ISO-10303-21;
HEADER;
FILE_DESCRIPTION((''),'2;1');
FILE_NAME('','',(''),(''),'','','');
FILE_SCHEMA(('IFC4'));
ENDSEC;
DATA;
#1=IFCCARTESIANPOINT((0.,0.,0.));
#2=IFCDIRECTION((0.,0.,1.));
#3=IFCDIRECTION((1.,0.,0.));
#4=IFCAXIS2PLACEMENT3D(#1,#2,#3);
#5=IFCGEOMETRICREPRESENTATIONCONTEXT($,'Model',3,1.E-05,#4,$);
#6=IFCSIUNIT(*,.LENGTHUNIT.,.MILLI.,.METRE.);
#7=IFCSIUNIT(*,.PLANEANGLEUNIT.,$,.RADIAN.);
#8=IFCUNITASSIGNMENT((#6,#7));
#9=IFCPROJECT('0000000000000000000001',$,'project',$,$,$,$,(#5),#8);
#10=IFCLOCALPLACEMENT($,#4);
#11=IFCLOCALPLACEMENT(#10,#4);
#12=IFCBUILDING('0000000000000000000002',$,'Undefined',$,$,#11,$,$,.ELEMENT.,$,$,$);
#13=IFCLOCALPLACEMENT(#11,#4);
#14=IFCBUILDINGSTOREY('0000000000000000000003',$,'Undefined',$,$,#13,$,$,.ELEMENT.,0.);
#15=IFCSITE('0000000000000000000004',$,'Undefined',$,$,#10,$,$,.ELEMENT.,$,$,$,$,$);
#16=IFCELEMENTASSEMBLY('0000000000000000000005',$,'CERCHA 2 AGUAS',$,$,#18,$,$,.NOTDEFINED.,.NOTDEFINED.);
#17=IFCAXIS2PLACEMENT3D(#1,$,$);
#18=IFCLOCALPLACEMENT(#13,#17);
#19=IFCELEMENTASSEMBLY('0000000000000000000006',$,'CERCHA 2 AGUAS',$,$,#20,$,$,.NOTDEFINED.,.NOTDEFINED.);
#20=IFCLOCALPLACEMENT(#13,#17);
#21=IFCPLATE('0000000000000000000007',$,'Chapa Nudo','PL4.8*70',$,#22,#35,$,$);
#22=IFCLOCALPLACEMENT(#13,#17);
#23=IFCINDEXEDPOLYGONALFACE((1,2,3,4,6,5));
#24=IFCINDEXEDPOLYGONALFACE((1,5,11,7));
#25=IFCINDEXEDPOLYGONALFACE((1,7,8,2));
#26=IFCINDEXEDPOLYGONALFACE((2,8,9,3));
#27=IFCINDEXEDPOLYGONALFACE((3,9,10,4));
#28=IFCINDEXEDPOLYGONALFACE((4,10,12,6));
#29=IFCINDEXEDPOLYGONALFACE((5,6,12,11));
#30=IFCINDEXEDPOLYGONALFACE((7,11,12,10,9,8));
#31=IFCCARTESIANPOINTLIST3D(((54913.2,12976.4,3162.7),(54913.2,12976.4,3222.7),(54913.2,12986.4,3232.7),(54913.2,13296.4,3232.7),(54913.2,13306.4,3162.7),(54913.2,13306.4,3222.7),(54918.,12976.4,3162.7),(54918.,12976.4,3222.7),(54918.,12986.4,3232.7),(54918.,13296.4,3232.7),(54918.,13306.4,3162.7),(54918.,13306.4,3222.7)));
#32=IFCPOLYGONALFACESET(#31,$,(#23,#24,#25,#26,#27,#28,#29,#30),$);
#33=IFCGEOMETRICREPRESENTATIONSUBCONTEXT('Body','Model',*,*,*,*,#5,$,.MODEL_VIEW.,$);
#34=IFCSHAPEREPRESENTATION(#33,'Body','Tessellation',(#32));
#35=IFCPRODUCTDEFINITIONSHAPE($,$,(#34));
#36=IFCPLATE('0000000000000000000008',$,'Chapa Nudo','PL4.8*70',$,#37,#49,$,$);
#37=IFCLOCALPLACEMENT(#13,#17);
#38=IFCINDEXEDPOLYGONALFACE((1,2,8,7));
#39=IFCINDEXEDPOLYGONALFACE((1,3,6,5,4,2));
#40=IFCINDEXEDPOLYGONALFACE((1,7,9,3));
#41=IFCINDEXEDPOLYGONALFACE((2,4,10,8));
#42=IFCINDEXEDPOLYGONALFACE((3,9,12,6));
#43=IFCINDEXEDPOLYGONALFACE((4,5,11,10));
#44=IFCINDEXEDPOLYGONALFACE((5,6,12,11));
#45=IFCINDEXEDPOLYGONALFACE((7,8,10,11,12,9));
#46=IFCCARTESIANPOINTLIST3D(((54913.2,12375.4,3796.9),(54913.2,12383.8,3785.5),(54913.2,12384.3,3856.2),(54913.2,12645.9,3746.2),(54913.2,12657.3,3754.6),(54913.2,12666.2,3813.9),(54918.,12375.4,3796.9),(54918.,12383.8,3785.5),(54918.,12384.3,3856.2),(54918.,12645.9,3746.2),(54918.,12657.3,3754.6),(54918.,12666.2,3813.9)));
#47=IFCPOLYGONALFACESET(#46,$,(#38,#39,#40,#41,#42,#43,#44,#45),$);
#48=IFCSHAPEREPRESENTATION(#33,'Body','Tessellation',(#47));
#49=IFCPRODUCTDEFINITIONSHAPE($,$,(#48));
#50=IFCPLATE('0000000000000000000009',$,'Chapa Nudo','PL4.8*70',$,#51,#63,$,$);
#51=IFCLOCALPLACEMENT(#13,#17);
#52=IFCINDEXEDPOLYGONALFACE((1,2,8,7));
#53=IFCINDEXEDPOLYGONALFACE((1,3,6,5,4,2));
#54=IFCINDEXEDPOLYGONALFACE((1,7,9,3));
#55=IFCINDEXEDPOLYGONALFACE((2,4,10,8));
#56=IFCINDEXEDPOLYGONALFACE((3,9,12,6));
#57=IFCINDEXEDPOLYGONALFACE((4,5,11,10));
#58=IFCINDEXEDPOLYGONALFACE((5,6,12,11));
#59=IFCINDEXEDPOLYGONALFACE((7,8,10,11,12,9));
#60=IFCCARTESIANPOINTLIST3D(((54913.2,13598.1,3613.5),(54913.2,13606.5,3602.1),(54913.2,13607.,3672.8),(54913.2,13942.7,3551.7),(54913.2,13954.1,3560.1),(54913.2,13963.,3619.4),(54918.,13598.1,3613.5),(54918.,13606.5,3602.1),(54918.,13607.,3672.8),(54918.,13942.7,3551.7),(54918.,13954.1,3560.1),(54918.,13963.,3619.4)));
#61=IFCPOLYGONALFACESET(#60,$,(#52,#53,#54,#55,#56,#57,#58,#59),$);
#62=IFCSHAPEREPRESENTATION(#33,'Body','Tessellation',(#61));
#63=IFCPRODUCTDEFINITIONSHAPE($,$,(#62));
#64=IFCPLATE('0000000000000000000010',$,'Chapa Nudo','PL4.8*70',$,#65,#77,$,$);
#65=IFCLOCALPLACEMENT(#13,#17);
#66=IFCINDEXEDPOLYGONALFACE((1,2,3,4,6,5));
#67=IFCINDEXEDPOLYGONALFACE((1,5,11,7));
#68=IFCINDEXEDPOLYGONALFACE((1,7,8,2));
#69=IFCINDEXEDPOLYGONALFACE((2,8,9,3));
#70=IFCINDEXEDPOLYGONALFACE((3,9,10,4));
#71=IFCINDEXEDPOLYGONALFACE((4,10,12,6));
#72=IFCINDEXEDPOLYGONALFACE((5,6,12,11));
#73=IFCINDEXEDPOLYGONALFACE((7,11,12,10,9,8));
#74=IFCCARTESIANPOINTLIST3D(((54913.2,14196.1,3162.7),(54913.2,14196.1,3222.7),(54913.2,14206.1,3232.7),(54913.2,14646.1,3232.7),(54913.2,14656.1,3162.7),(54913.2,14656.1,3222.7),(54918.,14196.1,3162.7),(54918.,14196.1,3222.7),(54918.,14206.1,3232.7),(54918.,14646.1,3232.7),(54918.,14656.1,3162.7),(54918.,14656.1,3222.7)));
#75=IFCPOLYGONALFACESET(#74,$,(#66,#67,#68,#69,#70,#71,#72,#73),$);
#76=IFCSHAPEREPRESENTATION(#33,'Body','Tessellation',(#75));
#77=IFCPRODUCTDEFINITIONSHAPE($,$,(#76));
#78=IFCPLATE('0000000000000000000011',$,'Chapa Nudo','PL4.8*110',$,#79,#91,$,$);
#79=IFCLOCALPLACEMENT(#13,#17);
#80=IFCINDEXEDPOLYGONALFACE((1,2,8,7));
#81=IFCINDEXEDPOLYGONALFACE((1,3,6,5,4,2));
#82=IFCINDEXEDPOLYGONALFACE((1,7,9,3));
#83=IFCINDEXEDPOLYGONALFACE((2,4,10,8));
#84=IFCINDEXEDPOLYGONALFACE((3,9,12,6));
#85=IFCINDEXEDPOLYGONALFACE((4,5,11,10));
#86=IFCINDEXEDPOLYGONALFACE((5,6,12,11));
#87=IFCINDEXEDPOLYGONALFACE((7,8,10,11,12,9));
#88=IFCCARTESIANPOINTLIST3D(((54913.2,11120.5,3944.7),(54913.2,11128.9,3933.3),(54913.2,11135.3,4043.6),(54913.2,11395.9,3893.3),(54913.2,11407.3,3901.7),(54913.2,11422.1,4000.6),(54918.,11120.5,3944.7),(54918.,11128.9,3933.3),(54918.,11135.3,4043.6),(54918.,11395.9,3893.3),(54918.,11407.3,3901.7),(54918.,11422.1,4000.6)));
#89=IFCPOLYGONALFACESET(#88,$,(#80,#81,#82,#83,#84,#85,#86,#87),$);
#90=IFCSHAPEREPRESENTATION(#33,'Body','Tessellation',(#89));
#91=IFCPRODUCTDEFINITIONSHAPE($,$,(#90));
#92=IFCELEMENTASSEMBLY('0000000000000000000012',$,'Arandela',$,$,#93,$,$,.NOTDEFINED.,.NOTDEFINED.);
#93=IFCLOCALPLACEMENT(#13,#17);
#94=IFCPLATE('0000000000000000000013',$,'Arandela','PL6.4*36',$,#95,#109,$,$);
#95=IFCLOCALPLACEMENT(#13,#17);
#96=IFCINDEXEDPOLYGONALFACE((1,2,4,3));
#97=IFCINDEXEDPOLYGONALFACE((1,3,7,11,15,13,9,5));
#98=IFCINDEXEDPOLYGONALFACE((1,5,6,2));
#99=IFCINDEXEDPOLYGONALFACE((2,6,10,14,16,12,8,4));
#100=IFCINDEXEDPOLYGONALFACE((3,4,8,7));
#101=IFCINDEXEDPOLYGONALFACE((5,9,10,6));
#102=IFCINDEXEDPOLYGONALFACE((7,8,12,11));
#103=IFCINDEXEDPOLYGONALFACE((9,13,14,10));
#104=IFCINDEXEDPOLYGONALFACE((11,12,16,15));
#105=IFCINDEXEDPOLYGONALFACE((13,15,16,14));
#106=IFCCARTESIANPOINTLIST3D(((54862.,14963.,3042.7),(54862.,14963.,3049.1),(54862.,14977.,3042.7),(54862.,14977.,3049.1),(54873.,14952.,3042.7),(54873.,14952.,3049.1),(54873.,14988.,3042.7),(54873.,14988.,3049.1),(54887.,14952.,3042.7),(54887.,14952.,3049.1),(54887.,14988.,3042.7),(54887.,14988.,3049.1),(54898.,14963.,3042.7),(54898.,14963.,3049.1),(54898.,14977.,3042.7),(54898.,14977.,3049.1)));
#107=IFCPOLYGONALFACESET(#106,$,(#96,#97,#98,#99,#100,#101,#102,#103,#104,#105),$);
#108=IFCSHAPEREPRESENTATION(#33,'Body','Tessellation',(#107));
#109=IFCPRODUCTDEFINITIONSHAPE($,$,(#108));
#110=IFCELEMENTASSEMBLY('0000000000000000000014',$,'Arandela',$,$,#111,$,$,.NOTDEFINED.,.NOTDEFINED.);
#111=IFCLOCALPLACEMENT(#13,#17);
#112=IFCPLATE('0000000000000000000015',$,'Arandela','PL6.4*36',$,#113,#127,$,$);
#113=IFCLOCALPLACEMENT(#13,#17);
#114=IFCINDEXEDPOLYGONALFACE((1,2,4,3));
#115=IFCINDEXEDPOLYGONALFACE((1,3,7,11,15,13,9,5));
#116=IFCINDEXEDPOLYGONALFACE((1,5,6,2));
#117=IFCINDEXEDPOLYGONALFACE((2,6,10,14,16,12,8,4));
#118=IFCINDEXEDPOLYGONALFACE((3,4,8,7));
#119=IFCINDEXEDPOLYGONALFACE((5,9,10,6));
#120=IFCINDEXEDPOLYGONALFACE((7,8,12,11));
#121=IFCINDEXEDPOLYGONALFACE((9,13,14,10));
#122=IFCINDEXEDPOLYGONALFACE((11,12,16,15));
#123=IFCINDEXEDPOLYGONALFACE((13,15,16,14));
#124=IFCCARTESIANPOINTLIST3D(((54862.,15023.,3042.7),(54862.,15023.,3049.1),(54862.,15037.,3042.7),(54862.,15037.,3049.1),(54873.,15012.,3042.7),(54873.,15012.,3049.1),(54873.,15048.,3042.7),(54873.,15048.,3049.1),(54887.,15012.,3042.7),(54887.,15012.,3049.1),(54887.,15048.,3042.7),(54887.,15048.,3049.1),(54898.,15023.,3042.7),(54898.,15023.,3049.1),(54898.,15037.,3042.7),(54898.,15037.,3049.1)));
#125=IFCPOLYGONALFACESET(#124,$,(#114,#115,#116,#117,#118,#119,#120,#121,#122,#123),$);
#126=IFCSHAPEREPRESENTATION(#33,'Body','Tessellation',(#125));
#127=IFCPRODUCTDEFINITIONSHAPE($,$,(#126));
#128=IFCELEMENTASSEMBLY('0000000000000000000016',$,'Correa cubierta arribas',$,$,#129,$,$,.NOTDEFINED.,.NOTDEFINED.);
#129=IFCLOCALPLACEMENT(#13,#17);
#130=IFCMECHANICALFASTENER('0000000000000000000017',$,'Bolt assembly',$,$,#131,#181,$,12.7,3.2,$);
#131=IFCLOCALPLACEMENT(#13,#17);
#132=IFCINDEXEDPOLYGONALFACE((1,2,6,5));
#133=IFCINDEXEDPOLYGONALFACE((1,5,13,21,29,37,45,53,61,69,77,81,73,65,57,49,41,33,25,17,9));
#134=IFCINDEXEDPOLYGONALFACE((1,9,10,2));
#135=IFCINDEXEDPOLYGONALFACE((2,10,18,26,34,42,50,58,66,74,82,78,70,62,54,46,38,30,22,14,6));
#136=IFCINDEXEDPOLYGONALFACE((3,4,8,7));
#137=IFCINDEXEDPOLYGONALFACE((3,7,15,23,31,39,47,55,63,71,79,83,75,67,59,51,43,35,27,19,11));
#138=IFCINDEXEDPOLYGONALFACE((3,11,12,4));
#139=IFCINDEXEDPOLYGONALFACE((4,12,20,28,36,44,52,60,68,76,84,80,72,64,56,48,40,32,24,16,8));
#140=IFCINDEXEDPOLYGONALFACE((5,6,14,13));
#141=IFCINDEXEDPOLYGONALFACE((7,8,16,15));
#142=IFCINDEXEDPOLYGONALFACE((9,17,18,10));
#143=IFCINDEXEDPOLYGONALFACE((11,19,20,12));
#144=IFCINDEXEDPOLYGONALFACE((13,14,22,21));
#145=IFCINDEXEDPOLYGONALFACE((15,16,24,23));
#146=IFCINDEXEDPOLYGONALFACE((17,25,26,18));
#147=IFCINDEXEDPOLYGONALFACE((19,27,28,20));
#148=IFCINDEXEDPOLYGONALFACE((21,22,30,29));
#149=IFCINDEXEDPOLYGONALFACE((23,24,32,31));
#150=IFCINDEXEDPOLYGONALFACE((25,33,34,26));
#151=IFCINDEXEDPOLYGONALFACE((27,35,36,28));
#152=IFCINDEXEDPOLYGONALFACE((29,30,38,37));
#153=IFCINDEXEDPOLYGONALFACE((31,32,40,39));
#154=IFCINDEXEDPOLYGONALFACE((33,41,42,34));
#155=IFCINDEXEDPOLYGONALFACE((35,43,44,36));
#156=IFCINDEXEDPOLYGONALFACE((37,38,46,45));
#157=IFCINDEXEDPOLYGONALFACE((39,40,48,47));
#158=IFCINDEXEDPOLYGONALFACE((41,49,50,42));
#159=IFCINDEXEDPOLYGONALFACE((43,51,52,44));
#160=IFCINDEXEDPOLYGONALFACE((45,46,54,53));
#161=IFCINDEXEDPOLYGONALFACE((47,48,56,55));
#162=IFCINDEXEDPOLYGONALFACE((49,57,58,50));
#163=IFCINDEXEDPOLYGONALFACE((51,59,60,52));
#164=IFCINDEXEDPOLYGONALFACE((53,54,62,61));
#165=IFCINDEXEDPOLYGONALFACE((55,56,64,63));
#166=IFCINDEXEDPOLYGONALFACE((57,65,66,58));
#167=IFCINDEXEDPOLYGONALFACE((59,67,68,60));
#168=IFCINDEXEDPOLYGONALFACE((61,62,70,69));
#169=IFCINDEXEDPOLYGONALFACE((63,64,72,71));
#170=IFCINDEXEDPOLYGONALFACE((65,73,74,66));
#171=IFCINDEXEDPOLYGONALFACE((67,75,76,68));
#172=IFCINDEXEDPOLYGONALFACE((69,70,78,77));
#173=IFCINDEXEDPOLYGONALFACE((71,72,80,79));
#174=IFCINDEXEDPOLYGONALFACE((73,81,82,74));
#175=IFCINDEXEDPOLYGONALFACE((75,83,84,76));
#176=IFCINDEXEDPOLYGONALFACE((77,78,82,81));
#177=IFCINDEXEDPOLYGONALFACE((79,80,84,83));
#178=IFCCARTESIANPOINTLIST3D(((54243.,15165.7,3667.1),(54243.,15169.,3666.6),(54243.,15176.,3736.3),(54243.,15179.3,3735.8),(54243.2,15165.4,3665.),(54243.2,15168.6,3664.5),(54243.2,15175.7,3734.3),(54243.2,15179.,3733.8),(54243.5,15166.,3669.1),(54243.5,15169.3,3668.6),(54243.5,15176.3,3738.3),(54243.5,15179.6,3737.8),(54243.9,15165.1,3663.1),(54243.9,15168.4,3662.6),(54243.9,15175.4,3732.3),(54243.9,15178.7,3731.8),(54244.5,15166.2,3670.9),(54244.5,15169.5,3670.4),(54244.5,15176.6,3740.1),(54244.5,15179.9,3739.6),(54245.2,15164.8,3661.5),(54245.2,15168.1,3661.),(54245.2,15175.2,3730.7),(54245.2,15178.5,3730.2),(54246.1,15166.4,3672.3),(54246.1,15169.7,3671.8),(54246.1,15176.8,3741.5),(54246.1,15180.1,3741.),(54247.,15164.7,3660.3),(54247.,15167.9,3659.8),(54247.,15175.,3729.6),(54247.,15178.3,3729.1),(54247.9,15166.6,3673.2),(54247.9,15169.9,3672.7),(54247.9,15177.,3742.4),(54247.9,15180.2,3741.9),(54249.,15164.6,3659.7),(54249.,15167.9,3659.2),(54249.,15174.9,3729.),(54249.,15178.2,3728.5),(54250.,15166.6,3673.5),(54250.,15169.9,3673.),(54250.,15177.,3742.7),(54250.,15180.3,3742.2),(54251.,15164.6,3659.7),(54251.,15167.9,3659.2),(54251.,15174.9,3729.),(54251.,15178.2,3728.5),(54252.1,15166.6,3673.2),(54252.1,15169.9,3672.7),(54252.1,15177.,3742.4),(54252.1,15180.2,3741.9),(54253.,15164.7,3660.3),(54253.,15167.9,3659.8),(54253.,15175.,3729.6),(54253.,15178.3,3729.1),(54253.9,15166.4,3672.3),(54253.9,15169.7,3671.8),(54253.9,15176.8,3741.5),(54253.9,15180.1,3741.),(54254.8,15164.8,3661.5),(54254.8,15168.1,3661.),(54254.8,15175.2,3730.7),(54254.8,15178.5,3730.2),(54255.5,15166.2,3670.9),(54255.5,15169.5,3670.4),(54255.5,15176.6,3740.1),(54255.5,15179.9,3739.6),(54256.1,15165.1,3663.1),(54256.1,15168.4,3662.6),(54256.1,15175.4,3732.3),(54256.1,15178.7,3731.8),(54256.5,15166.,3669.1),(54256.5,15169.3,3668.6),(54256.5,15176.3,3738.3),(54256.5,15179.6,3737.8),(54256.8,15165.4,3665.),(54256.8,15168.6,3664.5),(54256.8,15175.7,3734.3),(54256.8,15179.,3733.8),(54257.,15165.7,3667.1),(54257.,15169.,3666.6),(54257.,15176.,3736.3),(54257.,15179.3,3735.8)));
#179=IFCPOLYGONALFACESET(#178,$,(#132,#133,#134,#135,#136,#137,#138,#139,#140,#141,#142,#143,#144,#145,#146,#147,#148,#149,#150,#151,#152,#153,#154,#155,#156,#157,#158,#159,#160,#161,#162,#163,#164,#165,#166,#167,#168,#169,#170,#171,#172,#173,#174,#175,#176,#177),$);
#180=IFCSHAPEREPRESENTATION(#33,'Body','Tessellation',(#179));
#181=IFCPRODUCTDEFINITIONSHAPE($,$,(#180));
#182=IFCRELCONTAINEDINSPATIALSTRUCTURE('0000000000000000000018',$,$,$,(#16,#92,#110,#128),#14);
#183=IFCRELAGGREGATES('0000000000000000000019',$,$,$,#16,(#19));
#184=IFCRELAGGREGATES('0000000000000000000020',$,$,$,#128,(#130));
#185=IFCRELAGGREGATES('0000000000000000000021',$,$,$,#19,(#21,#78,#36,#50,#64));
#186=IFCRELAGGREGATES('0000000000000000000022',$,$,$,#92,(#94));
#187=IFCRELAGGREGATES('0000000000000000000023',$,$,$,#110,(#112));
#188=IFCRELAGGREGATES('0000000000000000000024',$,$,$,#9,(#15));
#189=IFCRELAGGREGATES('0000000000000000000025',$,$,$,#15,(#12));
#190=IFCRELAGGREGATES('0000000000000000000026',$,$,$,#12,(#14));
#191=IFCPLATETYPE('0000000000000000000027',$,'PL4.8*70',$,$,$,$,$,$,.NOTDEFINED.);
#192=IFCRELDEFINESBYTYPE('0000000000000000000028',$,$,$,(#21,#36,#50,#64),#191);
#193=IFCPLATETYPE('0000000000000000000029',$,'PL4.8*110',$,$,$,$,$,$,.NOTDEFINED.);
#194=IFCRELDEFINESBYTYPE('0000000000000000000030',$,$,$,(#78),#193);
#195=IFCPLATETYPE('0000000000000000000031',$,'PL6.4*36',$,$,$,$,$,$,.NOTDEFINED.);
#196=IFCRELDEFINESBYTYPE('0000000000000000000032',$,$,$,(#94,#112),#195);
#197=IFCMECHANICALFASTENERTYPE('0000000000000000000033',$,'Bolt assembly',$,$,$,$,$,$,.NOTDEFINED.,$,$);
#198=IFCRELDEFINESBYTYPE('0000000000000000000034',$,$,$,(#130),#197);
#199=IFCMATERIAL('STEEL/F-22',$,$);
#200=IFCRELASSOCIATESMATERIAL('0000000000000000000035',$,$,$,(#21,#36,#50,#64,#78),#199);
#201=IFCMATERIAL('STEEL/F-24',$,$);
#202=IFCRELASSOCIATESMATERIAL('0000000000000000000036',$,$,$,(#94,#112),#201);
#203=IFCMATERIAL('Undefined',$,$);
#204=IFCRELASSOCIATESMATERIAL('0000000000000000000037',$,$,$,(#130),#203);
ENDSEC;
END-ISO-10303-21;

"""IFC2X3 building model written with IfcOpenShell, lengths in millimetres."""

from ifc_helpers import new_model, si_unit, frame, origin_with_axes, origin_2d_with_axis, place, context, subcontext, project, spatial, polyline, circle, outline, extrude, source, transform, mapped, material, type_object, element, aggregate, save


model = new_model("IFC2X3")

# Units and contexts
model_context = context("Model", 3, precision=1e-05, world=origin_with_axes())
body_context = subcontext(model_context, "Body", "Model", "MODEL_VIEW")
ifc_project = project(units=[si_unit("LENGTHUNIT", "METRE", prefix="MILLI"), si_unit("PLANEANGLEUNIT", "RADIAN")], contexts=[model_context])

# Site, building, storey
site_placement = place(None, origin_with_axes())
site = spatial("IfcSite", under=ifc_project, at=site_placement, Name="Undefined", CompositionType="ELEMENT")
building_placement = place(site_placement, origin_with_axes())
building = spatial("IfcBuilding", under=site, at=building_placement, Name="Undefined", CompositionType="ELEMENT")
storey_placement = place(building_placement, origin_with_axes())
storey = spatial("IfcBuildingStorey", under=building, at=storey_placement, Name="Undefined", CompositionType="ELEMENT", Elevation=0.0)

# Element assemblies
assembly_1_placement = place(storey_placement, origin_with_axes())
assembly_1 = element("IfcElementAssembly", 1, at=assembly_1_placement, inside=storey, Name="CERCHA 2 AGUAS", AssemblyPlace="NOTDEFINED", PredefinedType="NOTDEFINED")
assembly_2_placement = place(assembly_1_placement, origin_with_axes())
assembly_2 = element("IfcElementAssembly", 2, at=assembly_2_placement, Name="CERCHA 2 AGUAS", AssemblyPlace="NOTDEFINED", PredefinedType="NOTDEFINED")
ifc_material_1 = material(Name="STEEL/F-22")

# Shared definitions
ifc_material_2 = material(Name="STEEL/F-24")
aggregate(assembly_1, [assembly_2])

# Plates
plate_type_1 = type_object("IfcPlateType", Name="PL4.8*70", PredefinedType="NOTDEFINED")
plate_1_placement = place(assembly_2_placement, frame((54915.6, 13306.4, 3232.7), z_axis=(-1.0, 0.0, 0.0), x_axis=(0.0, 0.0, -1.0)))
plate_1 = element("IfcPlate", 3, at=plate_1_placement, type_object=plate_type_1, material=ifc_material_1, Name="Chapa Nudo", Description="PL4.8*70", context=body_context, shape_type="SweptSolid", body=[
    extrude(outline(polyline([(0.0, 10.0), (10.0, 0.0), (70.0, 0.0), (70.0, 330.0), (10.0, 330.0), (0.0, 320.0), (0.0, 10.0)])), frame((0.0, 0.0, -2.4), z_axis=(0.0, 0.0, 1.0), x_axis=(1.0, 0.0, 0.0)), (0.0, 0.0, 1.0), 4.8),
])
plate_2_placement = place(assembly_2_placement, frame((54915.6, 12666.2, 3813.9), z_axis=(-1.0, 0.0, 0.0), x_axis=(0.0, -0.14834, -0.988936)))
plate_2 = element("IfcPlate", 4, at=plate_2_placement, type_object=plate_type_1, material=ifc_material_1, Name="Chapa Nudo", Description="PL4.8*70", context=body_context, shape_type="SweptSolid", body=[
    extrude(outline(polyline([(0.0, 0.0), (60.0, 0.0), (70.0, 10.0), (70.0, 275.0), (60.0, 285.0), (0.0, 285.0), (0.0, 0.0)])), frame((0.0, 0.0, -2.4), z_axis=(0.0, 0.0, 1.0), x_axis=(1.0, 0.0, 0.0)), (0.0, 0.0, 1.0), 4.8),
])
plate_3_placement = place(assembly_2_placement, frame((54915.6, 13963.0, 3619.4), z_axis=(-1.0, 0.0, 0.0), x_axis=(0.0, -0.148337, -0.988937)))
plate_3 = element("IfcPlate", 5, at=plate_3_placement, type_object=plate_type_1, material=ifc_material_1, Name="Chapa Nudo", Description="PL4.8*70", context=body_context, shape_type="SweptSolid", body=[
    extrude(outline(polyline([(0.0, 0.0), (60.0, 0.0), (70.0, 10.0), (70.0, 350.0), (60.0, 360.0), (0.0, 360.0), (0.0, 0.0)])), frame((0.0, 0.0, -2.4), z_axis=(0.0, 0.0, 1.0), x_axis=(1.0, 0.0, 0.0)), (0.0, 0.0, 1.0), 4.8),
])
plate_4_placement = place(assembly_2_placement, frame((54915.6, 14656.1, 3232.7), z_axis=(-1.0, 0.0, 0.0), x_axis=(0.0, 0.0, -1.0)))
plate_4 = element("IfcPlate", 6, at=plate_4_placement, type_object=plate_type_1, material=ifc_material_1, Name="Chapa Nudo", Description="PL4.8*70", context=body_context, shape_type="SweptSolid", body=[
    extrude(outline(polyline([(0.0, 10.0), (10.0, 0.0), (70.0, 0.0), (70.0, 460.0), (10.0, 460.0), (0.0, 450.0), (0.0, 10.0)])), frame((0.0, 0.0, -2.4), z_axis=(0.0, 0.0, 1.0), x_axis=(1.0, 0.0, 0.0)), (0.0, 0.0, 1.0), 4.8),
])
plate_type_2 = type_object("IfcPlateType", Name="PL4.8*110", PredefinedType="NOTDEFINED")
plate_5_placement = place(assembly_2_placement, frame((54915.6, 11422.1, 4000.6), z_axis=(-1.0, 0.0, 0.0), x_axis=(0.0, -0.148339, -0.988937)))
plate_5 = element("IfcPlate", 7, at=plate_5_placement, type_object=plate_type_2, material=ifc_material_1, Name="Chapa Nudo", Description="PL4.8*110", context=body_context, shape_type="SweptSolid", body=[
    extrude(outline(polyline([(0.0, 0.0), (100.0, 0.0), (110.0, 10.0), (110.0, 280.0), (100.0, 290.0), (0.0, 290.0), (0.0, 0.0)])), frame((0.0, 0.0, -2.4), z_axis=(0.0, 0.0, 1.0), x_axis=(1.0, 0.0, 0.0)), (0.0, 0.0, 1.0), 4.8),
])

# Element assemblies, plates
assembly_3_placement = place(storey_placement, origin_with_axes())
assembly_3 = element("IfcElementAssembly", 8, at=assembly_3_placement, inside=storey, Name="Arandela", AssemblyPlace="NOTDEFINED", PredefinedType="NOTDEFINED")
plate_type_3 = type_object("IfcPlateType", Name="PL6.4*36", PredefinedType="NOTDEFINED")
plate_6_placement = place(assembly_3_placement, frame((54862.0, 14988.0, 3045.9), z_axis=(0.0, 0.0, 1.0), x_axis=(0.0, -1.0, 0.0)))
plate_6 = element("IfcPlate", 9, at=plate_6_placement, type_object=plate_type_3, material=ifc_material_2, Name="Arandela", Description="PL6.4*36", context=body_context, shape_type="SweptSolid", body=[
    extrude(outline(polyline([(0.0, 11.0), (11.0, 0.0), (25.0, 0.0), (36.0, 11.0), (36.0, 25.0), (25.0, 36.0), (11.0, 36.0), (0.0, 25.0), (0.0, 11.0)])), frame((0.0, 0.0, -3.2), z_axis=(0.0, 0.0, 1.0), x_axis=(1.0, 0.0, 0.0)), (0.0, 0.0, 1.0), 6.4),
])
assembly_4_placement = place(storey_placement, origin_with_axes())
assembly_4 = element("IfcElementAssembly", 10, at=assembly_4_placement, inside=storey, Name="Arandela", AssemblyPlace="NOTDEFINED", PredefinedType="NOTDEFINED")
plate_7_placement = place(assembly_4_placement, frame((54862.0, 15048.0, 3045.9), z_axis=(0.0, 0.0, 1.0), x_axis=(0.0, -1.0, 0.0)))
plate_7 = element("IfcPlate", 11, at=plate_7_placement, type_object=plate_type_3, material=ifc_material_2, Name="Arandela", Description="PL6.4*36", context=body_context, shape_type="SweptSolid", body=[
    extrude(outline(polyline([(0.0, 11.0), (11.0, 0.0), (25.0, 0.0), (36.0, 11.0), (36.0, 25.0), (25.0, 36.0), (11.0, 36.0), (0.0, 25.0), (0.0, 11.0)])), frame((0.0, 0.0, -3.2), z_axis=(0.0, 0.0, 1.0), x_axis=(1.0, 0.0, 0.0)), (0.0, 0.0, 1.0), 6.4),
])

# Element assembly, mechanical fastener
ifc_material_3 = material(Name="Undefined")
mechanical_fastener_type = type_object("IfcMechanicalFastenerType", Name="Bolt assembly")
assembly_5_placement = place(storey_placement, origin_with_axes())
assembly_5 = element("IfcElementAssembly", 12, at=assembly_5_placement, inside=storey, Name="Correa cubierta arribas", AssemblyPlace="NOTDEFINED", PredefinedType="NOTDEFINED")
shared_shape_1 = source(origin_with_axes(), body_context, "Body", "SweptSolid", [
    extrude(circle(Radius=7.0, at=origin_2d_with_axis()), frame((0.0, 6.4, 0.0), z_axis=(0.0, 1.0, 0.0), x_axis=(1.0, 0.0, 0.0)), (0.0, 0.0, 1.0), 3.3),
])
mechanical_fastener_1_placement = place(assembly_5_placement, frame((54250.0, 15159.3, 3667.5), z_axis=(-1.0, 0.0, 0.0), x_axis=(0.0, 0.148209, 0.988956)))
mechanical_fastener_1 = element("IfcMechanicalFastener", 13, at=mechanical_fastener_1_placement, type_object=mechanical_fastener_type, material=ifc_material_3, Name="Bolt assembly", NominalDiameter=12.7, NominalLength=3.2, context=body_context, shape_type="MappedRepresentation", body=[
    mapped(shared_shape_1, transform((0.0, 0.0, 0.0))),
    mapped(shared_shape_1, transform((70.0, 0.0, 0.0))),
])
aggregate(assembly_5, [mechanical_fastener_1])

aggregate(assembly_2, [plate_1, plate_5, plate_2, plate_3, plate_4])
aggregate(assembly_3, [plate_6])
aggregate(assembly_4, [plate_7])

save(model, "model.ifc")
